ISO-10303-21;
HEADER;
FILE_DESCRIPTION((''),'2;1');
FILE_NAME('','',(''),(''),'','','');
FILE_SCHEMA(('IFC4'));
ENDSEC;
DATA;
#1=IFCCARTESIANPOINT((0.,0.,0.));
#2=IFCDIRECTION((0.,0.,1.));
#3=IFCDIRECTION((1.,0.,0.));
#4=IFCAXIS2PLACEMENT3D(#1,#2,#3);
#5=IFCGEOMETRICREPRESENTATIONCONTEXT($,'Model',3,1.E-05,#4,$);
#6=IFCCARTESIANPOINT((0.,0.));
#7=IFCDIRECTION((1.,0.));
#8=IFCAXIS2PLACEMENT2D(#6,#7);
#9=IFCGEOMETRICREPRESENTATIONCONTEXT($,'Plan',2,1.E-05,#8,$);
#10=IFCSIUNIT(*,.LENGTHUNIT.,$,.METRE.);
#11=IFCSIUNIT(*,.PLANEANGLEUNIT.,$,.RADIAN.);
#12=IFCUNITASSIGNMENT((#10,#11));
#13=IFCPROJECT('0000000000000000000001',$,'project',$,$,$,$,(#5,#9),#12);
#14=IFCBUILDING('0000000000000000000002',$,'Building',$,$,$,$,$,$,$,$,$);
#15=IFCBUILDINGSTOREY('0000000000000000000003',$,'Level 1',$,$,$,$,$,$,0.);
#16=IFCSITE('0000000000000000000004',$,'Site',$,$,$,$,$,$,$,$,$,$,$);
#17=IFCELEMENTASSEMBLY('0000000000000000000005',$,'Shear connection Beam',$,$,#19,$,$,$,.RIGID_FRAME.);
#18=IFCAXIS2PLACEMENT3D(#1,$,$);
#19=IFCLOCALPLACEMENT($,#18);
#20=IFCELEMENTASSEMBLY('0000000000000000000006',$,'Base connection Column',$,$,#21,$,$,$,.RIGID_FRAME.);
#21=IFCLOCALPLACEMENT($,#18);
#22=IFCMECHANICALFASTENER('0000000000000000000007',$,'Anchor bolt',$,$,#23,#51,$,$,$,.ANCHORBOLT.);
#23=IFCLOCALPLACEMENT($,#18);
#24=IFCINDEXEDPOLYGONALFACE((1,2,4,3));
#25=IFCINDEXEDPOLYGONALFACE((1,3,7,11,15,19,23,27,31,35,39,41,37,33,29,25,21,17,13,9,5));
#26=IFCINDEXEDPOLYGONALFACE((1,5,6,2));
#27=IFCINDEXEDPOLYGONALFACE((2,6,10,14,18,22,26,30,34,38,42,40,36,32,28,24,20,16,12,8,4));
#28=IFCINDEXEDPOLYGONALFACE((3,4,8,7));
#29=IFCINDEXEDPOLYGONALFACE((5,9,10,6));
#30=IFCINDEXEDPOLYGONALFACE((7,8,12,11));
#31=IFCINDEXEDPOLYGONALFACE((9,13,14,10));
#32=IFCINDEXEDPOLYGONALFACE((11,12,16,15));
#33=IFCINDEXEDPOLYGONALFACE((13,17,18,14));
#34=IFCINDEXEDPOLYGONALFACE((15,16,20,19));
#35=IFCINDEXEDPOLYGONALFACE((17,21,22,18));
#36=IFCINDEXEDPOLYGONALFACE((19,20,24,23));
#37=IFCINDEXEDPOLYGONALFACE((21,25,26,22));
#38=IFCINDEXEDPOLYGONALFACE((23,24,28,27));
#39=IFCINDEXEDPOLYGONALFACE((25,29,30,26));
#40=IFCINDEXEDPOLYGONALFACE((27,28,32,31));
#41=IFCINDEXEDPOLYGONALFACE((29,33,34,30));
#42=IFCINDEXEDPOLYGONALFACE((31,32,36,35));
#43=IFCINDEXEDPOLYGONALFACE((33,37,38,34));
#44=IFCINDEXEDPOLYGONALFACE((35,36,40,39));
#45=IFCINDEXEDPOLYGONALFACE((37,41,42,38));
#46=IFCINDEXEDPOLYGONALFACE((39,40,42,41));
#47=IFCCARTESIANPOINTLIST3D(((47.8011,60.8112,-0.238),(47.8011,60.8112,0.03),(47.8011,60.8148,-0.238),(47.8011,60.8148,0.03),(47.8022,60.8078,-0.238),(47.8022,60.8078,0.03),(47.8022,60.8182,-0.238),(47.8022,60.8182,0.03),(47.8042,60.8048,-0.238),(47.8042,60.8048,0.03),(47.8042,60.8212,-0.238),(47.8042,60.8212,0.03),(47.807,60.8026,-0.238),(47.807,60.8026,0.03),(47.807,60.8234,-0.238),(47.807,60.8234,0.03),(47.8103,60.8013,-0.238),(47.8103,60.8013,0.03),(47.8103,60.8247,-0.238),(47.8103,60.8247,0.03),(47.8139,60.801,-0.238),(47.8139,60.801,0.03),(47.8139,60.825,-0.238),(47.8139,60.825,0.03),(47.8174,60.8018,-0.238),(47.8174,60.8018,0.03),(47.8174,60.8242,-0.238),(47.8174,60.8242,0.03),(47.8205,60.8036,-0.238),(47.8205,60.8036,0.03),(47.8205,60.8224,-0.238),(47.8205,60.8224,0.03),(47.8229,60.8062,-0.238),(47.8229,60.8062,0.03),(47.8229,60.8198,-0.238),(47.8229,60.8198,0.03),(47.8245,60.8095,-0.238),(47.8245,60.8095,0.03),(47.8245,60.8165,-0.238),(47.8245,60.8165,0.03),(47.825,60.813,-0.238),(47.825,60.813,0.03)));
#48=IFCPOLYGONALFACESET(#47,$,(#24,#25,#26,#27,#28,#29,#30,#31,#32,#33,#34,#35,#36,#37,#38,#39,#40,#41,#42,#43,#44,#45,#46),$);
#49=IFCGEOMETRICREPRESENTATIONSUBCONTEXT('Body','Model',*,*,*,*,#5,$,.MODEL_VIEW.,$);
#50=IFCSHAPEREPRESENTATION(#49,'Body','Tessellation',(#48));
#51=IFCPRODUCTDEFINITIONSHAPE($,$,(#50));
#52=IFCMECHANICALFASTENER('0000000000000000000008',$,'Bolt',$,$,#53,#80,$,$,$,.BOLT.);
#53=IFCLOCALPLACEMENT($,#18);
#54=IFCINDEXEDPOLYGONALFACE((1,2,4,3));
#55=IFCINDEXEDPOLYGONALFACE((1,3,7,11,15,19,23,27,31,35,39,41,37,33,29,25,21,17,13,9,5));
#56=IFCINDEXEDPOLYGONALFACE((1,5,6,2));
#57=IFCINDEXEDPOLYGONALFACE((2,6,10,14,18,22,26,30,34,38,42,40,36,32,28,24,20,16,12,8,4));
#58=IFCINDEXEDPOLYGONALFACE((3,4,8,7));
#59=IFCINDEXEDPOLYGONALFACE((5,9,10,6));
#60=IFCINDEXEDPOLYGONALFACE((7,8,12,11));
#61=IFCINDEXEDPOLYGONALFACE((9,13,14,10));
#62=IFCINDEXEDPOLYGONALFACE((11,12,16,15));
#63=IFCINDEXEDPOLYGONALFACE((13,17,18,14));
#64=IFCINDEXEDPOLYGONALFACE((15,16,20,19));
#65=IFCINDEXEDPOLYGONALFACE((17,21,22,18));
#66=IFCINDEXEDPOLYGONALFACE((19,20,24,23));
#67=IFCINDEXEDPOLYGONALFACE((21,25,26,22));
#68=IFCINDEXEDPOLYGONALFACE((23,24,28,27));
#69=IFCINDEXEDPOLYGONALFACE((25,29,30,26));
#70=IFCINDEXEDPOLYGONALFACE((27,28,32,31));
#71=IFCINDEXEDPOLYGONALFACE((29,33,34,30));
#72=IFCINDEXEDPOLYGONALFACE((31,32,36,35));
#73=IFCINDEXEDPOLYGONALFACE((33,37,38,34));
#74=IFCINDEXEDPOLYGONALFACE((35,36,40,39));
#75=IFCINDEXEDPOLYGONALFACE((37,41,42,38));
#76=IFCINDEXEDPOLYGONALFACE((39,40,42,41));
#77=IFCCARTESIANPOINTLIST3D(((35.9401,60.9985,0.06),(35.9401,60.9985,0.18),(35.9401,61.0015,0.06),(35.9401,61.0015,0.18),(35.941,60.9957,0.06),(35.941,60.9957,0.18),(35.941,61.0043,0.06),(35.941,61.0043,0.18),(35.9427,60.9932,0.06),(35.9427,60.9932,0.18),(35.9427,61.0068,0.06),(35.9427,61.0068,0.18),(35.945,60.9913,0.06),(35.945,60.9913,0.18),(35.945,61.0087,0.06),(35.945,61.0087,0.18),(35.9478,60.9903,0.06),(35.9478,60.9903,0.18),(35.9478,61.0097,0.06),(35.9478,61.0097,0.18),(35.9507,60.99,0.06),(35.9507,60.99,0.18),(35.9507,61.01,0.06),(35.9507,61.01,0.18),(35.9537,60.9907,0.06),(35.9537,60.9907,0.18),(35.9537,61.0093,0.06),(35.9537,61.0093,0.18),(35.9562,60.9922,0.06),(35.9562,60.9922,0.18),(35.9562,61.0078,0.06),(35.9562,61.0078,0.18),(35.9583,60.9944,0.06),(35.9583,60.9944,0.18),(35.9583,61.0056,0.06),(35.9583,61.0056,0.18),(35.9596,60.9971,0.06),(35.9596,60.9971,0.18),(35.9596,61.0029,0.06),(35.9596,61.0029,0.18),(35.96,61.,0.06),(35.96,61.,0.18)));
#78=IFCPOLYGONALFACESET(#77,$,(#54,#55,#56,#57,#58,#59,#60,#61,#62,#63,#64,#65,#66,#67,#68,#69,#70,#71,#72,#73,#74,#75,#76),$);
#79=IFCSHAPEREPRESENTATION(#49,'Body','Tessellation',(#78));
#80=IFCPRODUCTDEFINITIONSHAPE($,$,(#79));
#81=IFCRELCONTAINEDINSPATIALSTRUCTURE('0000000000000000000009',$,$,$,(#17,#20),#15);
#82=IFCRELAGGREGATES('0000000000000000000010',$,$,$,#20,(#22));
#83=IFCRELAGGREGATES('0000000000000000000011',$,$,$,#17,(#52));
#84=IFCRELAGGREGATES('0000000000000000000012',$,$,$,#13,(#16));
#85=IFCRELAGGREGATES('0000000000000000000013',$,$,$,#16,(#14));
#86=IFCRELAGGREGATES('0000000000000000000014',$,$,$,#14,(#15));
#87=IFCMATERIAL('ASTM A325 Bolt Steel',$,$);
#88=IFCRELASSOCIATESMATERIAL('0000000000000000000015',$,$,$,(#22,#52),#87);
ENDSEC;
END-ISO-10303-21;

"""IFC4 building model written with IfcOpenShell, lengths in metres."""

from ifc_helpers import new_model, si_unit, frame, origin_with_axes, origin_2d, origin_2d_with_axis, place, context, subcontext, project, spatial, circle, extrude, material, element, aggregate, save


model = new_model("IFC4")

# Units and contexts
model_context = context("Model", 3, precision=1e-05, world=origin_with_axes())
plan_context = context("Plan", 2, precision=1e-05, world=origin_2d_with_axis())
body_context = subcontext(model_context, "Body", "Model", "MODEL_VIEW")
ifc_project = project(units=[si_unit("LENGTHUNIT", "METRE"), si_unit("PLANEANGLEUNIT", "RADIAN")], contexts=[model_context, plan_context])

# Site, building, storey
site = spatial("IfcSite", under=ifc_project, Name="Site")
building = spatial("IfcBuilding", under=site, Name="Building")
storey = spatial("IfcBuildingStorey", under=building, Name="Level 1", Elevation=0.0)

# Element assembly
assembly_1 = element("IfcElementAssembly", 1, inside=storey, Name="Shear connection Beam", PredefinedType="RIGID_FRAME")

# Shared definitions
ifc_material_1 = material(Name="ASTM A325 Bolt Steel")

# Element assembly, mechanical fastener
assembly_2 = element("IfcElementAssembly", 2, inside=storey, Name="Base connection Column", PredefinedType="RIGID_FRAME")
mechanical_fastener_1_placement = place(None, frame((47.813, 60.813, -0.238), z_axis=(0.0, 0.0, 1.0), x_axis=(1.0, 0.0, 0.0)))
mechanical_fastener_1 = element("IfcMechanicalFastener", 3, at=mechanical_fastener_1_placement, material=ifc_material_1, Name="Anchor bolt", PredefinedType="ANCHORBOLT", context=body_context, shape_type="SweptSolid", body=[
    extrude(circle(Radius=0.012, at=origin_2d()), origin_with_axes(), (0.0, 0.0, 1.0), 0.268),
])
aggregate(assembly_2, [mechanical_fastener_1])

# Mechanical fastener
mechanical_fastener_2_placement = place(None, frame((35.95, 61.0, 0.06), z_axis=(0.0, 0.0, 1.0), x_axis=(1.0, 0.0, 0.0)))
mechanical_fastener_2 = element("IfcMechanicalFastener", 4, at=mechanical_fastener_2_placement, material=ifc_material_1, Name="Bolt", PredefinedType="BOLT", context=body_context, shape_type="SweptSolid", body=[
    extrude(circle(Radius=0.01, at=origin_2d()), origin_with_axes(), (0.0, 0.0, 1.0), 0.12),
])
aggregate(assembly_1, [mechanical_fastener_2])

save(model, "model.ifc")
